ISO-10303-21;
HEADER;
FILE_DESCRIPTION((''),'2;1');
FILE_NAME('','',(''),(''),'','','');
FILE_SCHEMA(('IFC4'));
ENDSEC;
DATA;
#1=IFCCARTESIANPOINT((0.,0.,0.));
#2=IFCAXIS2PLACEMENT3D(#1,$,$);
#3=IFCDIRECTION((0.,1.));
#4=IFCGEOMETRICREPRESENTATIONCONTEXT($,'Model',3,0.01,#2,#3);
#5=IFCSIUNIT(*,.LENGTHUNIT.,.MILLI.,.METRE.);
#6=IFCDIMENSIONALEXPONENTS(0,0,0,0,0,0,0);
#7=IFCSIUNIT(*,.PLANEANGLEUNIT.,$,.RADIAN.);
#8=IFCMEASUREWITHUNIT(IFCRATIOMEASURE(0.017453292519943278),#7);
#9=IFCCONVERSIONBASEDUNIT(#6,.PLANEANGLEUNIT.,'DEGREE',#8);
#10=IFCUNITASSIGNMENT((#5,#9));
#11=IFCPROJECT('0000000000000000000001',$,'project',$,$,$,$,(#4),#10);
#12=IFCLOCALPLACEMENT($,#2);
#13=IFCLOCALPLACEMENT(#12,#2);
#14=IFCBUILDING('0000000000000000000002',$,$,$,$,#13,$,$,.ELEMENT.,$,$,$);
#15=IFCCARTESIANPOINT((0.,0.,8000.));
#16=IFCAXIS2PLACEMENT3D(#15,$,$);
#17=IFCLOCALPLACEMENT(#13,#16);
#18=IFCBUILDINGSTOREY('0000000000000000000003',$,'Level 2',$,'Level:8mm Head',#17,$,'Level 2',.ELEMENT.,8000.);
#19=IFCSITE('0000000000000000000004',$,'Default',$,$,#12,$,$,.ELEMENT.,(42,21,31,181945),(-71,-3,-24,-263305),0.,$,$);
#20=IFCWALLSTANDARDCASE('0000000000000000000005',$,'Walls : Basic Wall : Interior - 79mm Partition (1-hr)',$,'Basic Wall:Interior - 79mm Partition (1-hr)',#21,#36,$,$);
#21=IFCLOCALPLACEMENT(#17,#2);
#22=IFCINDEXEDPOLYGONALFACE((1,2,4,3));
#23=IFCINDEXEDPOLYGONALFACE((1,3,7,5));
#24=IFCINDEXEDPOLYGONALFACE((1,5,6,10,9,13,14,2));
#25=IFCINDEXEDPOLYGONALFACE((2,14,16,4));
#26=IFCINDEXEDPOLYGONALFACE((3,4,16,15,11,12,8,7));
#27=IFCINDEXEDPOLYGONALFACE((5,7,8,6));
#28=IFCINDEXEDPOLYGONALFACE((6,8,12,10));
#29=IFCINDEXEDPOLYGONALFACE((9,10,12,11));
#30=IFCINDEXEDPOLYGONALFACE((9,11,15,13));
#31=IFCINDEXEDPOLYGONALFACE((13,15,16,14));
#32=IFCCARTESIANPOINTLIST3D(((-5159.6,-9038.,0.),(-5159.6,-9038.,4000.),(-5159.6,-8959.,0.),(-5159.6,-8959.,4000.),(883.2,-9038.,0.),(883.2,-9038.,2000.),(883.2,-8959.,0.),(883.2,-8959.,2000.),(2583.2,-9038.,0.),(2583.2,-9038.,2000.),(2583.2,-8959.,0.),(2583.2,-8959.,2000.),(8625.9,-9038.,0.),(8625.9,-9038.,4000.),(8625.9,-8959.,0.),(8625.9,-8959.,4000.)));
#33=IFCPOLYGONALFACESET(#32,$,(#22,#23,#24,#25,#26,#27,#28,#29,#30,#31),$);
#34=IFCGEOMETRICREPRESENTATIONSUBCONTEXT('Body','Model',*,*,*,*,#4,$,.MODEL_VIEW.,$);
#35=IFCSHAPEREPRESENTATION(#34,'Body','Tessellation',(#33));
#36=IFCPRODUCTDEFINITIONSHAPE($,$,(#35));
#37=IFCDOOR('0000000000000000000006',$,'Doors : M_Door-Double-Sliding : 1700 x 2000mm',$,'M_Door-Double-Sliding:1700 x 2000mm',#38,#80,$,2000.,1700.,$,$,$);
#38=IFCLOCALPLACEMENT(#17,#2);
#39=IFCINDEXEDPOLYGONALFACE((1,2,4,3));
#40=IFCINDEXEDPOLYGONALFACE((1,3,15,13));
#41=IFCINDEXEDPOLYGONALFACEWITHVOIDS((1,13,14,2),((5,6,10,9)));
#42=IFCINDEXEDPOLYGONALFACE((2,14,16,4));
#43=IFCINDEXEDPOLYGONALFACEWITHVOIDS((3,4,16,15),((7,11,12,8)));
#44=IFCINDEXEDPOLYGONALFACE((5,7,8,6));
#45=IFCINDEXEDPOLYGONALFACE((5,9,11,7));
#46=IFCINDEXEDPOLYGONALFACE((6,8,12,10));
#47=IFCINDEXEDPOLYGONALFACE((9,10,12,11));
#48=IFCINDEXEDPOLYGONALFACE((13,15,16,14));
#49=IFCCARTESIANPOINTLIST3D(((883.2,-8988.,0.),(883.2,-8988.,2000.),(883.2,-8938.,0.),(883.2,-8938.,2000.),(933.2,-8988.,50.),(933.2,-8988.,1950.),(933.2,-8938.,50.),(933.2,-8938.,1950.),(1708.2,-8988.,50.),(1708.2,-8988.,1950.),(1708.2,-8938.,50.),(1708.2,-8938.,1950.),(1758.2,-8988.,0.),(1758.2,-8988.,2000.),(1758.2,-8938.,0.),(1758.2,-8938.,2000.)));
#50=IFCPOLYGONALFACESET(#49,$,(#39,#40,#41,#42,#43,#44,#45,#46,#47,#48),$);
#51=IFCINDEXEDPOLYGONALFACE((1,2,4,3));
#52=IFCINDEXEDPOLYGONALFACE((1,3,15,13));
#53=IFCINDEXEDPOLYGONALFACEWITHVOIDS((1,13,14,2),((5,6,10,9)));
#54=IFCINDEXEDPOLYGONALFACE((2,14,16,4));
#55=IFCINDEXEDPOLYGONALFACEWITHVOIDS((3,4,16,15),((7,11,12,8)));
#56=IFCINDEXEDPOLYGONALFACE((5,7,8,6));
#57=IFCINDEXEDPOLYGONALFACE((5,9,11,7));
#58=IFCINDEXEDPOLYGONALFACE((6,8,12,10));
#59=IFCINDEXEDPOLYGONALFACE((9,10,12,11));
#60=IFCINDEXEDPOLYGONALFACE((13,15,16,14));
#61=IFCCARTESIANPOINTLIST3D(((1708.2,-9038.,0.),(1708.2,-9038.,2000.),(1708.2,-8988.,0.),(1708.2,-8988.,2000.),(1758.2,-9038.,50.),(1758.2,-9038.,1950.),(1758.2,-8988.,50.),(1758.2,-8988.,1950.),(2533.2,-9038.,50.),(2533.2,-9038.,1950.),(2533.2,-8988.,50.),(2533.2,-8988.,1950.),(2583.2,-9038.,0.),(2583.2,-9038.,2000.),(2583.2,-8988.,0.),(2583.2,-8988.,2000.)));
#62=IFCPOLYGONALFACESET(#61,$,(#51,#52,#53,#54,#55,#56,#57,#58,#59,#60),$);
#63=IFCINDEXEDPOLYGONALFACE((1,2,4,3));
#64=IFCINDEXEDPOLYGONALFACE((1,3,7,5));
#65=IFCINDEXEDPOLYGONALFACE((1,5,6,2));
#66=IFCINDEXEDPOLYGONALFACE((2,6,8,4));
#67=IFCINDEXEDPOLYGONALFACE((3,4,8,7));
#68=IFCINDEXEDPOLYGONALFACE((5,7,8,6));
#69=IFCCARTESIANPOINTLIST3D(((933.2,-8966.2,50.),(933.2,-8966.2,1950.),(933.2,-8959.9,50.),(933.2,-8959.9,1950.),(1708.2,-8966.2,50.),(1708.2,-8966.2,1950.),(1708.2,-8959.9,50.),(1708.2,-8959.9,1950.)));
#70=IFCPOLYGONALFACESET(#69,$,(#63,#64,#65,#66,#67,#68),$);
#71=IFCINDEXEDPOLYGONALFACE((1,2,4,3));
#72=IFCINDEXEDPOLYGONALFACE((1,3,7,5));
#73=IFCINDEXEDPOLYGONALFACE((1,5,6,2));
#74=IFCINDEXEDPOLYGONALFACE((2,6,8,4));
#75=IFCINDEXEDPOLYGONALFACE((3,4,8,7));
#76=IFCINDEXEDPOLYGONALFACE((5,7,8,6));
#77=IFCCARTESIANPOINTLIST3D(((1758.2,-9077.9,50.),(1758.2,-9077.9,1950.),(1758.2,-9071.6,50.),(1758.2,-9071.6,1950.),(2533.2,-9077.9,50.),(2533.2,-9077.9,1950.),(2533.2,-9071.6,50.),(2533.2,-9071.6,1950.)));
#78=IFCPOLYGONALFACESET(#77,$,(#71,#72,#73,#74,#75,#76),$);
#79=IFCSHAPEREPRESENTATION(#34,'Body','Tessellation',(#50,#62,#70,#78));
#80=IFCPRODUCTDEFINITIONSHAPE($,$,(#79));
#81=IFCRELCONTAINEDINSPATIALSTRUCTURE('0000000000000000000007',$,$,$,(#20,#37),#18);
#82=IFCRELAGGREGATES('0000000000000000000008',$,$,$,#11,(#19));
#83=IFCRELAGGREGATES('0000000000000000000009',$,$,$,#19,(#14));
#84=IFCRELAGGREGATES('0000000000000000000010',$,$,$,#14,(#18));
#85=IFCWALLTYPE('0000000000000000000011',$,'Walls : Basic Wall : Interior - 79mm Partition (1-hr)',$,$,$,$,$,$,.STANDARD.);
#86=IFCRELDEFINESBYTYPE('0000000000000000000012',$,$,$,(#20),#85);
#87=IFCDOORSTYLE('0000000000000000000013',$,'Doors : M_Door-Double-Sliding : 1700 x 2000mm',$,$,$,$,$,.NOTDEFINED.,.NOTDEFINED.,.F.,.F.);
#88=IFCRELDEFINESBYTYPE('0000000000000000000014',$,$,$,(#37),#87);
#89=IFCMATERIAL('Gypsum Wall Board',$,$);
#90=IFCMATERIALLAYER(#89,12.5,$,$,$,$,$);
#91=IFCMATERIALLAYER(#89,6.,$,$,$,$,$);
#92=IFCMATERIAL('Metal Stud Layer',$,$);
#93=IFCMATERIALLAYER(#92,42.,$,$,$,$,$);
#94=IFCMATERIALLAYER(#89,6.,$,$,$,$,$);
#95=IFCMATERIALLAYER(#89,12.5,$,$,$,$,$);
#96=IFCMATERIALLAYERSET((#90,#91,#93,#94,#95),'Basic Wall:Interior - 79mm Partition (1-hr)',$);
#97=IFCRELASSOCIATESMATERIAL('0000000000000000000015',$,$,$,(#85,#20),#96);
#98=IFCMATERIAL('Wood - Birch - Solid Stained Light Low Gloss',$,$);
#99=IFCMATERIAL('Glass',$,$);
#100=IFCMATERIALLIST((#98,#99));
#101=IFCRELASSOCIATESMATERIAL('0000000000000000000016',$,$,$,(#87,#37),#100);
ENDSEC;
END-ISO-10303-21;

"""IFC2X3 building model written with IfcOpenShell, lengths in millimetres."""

from ifc_helpers import new_model, entity, si_unit, converted_unit, direction, frame, frame_2d, origin, origin_2d_with_axis, place, context, subcontext, project, spatial, polyline, rectangle, outline, extrude, source, transform, mapped, material, material_list, layer, layer_set, layer_usage, type_object, type_shapes, element, fill, save


model = new_model("IFC2X3")

# Units and contexts
model_context = context("Model", 3, precision=0.01, world=origin(), true_north=direction((0.0, 1.0)))
body_context = subcontext(model_context, "Body", "Model", "MODEL_VIEW")
ifc_project = project(units=[si_unit("LENGTHUNIT", "METRE", prefix="MILLI"), converted_unit("PLANEANGLEUNIT", "DEGREE", entity("IfcRatioMeasure", 0.017453292519943278), si_unit("PLANEANGLEUNIT", "RADIAN"), dimensions=[0, 0, 0, 0, 0, 0, 0])], contexts=[model_context])

# Site, building, storey
site_placement = place(None, origin())
site = spatial("IfcSite", under=ifc_project, at=site_placement, Name="Default", CompositionType="ELEMENT", RefLatitude=(42, 21, 31, 181945), RefLongitude=(-71, -3, -24, -263305), RefElevation=0.0)
building_placement = place(site_placement, origin())
building = spatial("IfcBuilding", under=site, at=building_placement, CompositionType="ELEMENT")
storey_placement = place(building_placement, frame((0.0, 0.0, 8000.0)))
storey = spatial("IfcBuildingStorey", under=building, at=storey_placement, Name="Level 2", ObjectType="Level:8mm Head", LongName="Level 2", CompositionType="ELEMENT", Elevation=8000.0)

# Shared definitions
ifc_material_1 = material(Name="Metal Stud Layer")
ifc_material_2 = material(Name="Gypsum Wall Board")
ifc_layer_1 = layer(ifc_material_2, 12.5)
ifc_layer_2 = layer(ifc_material_2, 6.0)
ifc_layer_3 = layer(ifc_material_1, 42.0)
ifc_layer_4 = layer(ifc_material_2, 6.0)
ifc_layer_5 = layer(ifc_material_2, 12.5)
ifc_layer_set_1 = layer_set([ifc_layer_1, ifc_layer_2, ifc_layer_3, ifc_layer_4, ifc_layer_5], Name="Basic Wall:Interior - 79mm Partition (1-hr)")
ifc_layer_usage_1 = layer_usage(ifc_layer_set_1, "AXIS2", "NEGATIVE", 39.5)
wall_type_1 = type_object("IfcWallType", Name="Walls : Basic Wall : Interior - 79mm Partition (1-hr)", PredefinedType="STANDARD", material=ifc_layer_set_1)

# Wall, opening, door
ifc_material_3 = material(Name="Wood - Birch - Solid Stained Light Low Gloss")
ifc_material_4 = material(Name="Glass")
ifc_material_list = material_list([ifc_material_3, ifc_material_4])
door_style = type_object("IfcDoorStyle", Name="Doors : M_Door-Double-Sliding : 1700 x 2000mm", ConstructionType="NOTDEFINED", OperationType="NOTDEFINED", ParameterTakesPrecedence=False, Sizeable=False, material=ifc_material_list)
shared_shape = source(origin(), body_context, "Body", "SweptSolid", [
    extrude(outline(polyline([(-437.5, -1000.0), (437.5, -1000.0), (437.5, 1000.0), (-437.5, 1000.0), (-437.5, -1000.0)]), holes=[polyline([(-387.5, -950.0), (-387.5, 950.0), (387.5, 950.0), (387.5, -950.0), (-387.5, -950.0)])]), frame((1262.5, -21.0, 1000.0), z_axis=(0.0, 1.0, 0.0), x_axis=(1.0, 0.0, 0.0)), (0.0, 0.0, 1.0), 50.0),
    extrude(outline(polyline([(-1000.0, -437.5), (1000.0, -437.5), (1000.0, 437.5), (-1000.0, 437.5), (-1000.0, -437.5)]), holes=[polyline([(-950.0, -387.5), (-950.0, 387.5), (950.0, 387.5), (950.0, -387.5), (-950.0, -387.5)])]), frame((437.5, 29.0, 1000.0), z_axis=(0.0, 1.0, 0.0), x_axis=(0.0, 0.0, -1.0)), (0.0, 0.0, 1.0), 50.0),
    extrude(rectangle(XDim=6.3, YDim=775.0, at=frame_2d((0.0, 0.0), x_axis=(1.0, 0.0))), frame((1262.5, 4.0, 50.0), z_axis=(0.0, 0.0, 1.0), x_axis=(0.0, -1.0, 0.0)), (0.0, 0.0, 1.0), 1900.0),
    extrude(rectangle(XDim=6.4, YDim=775.0, at=origin_2d_with_axis()), frame((437.5, 115.7, 50.0), z_axis=(0.0, 0.0, 1.0), x_axis=(0.0, 1.0, 0.0)), (0.0, 0.0, 1.0), 1900.0),
])
type_shapes(door_style, [shared_shape])
wall_1_placement = place(storey_placement, frame((-5159.6, -8998.5, 0.0)))
wall_1 = element("IfcWallStandardCase", 1, at=wall_1_placement, inside=storey, type_object=wall_type_1, material=ifc_layer_usage_1, Name="Walls : Basic Wall : Interior - 79mm Partition (1-hr)", ObjectType="Basic Wall:Interior - 79mm Partition (1-hr)", context=body_context, shape_type="SweptSolid", body=[
    extrude(rectangle(XDim=13785.5, YDim=79.0, at=frame_2d((6892.8, 0.0), x_axis=(1.0, 0.0))), origin(), (0.0, 0.0, 1.0), 4000.0),
])
opening_1_placement = place(wall_1_placement, frame((7742.8, 39.5, 0.0)))
opening_1 = element("IfcOpeningElement", 2, at=opening_1_placement, cuts=wall_1, ObjectType="Opening", context=body_context, shape_type="SweptSolid", body=[
    extrude(rectangle(XDim=2000.0, YDim=1700.0, at=frame_2d((1000.0, 850.0), x_axis=(-1.0, 0.0))), frame((0.0, 0.0, 0.0), z_axis=(0.0, -1.0, 0.0), x_axis=(0.0, 0.0, 1.0)), (0.0, 0.0, 1.0), 79.0),
])
door_1_placement = place(opening_1_placement, frame((0.0, 0.0, 0.0), z_axis=(0.0, 0.0, 1.0), x_axis=(-1.0, 0.0, 0.0)))
door_1 = element("IfcDoor", 3, at=door_1_placement, inside=storey, type_object=door_style, material=ifc_material_list, Name="Doors : M_Door-Double-Sliding : 1700 x 2000mm", ObjectType="M_Door-Double-Sliding:1700 x 2000mm", OverallHeight=2000.0, OverallWidth=1700.0, context=body_context, shape_type="MappedRepresentation", body=[
    mapped(shared_shape, transform((0.0, 0.0, 0.0), scale=1.0)),
])
fill(opening_1, door_1)

save(model, "model.ifc")
